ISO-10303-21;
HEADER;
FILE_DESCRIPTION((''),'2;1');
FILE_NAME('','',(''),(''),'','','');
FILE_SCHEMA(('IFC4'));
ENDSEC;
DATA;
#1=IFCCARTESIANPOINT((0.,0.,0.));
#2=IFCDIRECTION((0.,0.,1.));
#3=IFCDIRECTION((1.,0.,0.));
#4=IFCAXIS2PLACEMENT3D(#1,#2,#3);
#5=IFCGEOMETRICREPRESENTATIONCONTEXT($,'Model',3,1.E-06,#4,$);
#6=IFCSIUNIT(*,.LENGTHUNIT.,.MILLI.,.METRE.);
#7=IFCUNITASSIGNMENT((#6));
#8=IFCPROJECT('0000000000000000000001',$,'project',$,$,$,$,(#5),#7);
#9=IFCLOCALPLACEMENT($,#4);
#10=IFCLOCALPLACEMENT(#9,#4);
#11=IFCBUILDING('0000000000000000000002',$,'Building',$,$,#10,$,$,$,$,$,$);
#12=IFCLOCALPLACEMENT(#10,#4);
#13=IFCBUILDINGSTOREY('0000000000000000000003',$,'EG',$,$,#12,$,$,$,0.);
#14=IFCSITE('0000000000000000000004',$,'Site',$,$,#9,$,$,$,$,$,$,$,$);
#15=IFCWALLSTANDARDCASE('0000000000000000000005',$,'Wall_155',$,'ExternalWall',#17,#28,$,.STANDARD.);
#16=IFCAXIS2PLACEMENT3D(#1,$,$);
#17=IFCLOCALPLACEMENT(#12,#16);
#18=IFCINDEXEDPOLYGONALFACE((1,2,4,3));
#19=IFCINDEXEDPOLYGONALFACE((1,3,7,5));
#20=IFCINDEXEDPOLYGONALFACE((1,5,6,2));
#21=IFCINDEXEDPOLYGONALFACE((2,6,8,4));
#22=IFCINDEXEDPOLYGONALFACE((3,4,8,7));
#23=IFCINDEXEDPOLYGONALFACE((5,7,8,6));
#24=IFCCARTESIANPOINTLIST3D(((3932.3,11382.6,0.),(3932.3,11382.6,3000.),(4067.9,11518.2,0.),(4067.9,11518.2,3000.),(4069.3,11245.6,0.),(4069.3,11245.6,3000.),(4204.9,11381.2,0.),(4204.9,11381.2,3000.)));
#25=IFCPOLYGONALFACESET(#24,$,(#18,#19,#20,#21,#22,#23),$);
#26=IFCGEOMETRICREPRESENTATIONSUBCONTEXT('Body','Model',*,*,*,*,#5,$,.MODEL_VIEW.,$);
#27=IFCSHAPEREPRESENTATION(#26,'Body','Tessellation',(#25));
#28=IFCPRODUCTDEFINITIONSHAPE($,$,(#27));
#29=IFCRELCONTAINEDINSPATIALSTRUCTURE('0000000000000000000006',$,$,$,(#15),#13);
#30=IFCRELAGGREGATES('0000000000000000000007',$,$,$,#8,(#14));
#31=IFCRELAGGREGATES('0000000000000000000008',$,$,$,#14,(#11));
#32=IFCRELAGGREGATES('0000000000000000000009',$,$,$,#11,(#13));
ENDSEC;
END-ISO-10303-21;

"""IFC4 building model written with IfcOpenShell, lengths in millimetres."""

from ifc_helpers import new_model, si_unit, frame, origin_with_axes, place, context, subcontext, project, spatial, rectangle, extrude, element, save


model = new_model("IFC4")

# Units and contexts
model_context = context("Model", 3, precision=1e-06, world=origin_with_axes())
body_context = subcontext(model_context, "Body", "Model", "MODEL_VIEW")
ifc_project = project(units=[si_unit("LENGTHUNIT", "METRE", prefix="MILLI")], contexts=[model_context])

# Site, building, storey
site_placement = place(None, origin_with_axes())
site = spatial("IfcSite", under=ifc_project, at=site_placement, Name="Site")
building_placement = place(site_placement, origin_with_axes())
building = spatial("IfcBuilding", under=site, at=building_placement, Name="Building")
storey_placement = place(building_placement, origin_with_axes())
storey = spatial("IfcBuildingStorey", under=building, at=storey_placement, Name="EG", Elevation=0.0)

# Wall
wall_1_placement = place(storey_placement, origin_with_axes())
element("IfcWallStandardCase", 1, at=wall_1_placement, inside=storey, Name="Wall_155", ObjectType="ExternalWall", PredefinedType="STANDARD", context=body_context, shape_type="SweptSolid", body=[
    extrude(rectangle(XDim=193.7, YDim=191.8), frame((4068.6, 11381.9, 0.0), z_axis=(0.0, 0.0, 1.0), x_axis=(-0.707107, 0.707107, 0.0)), (0.0, 0.0, 1.0), 3000.0),
])

save(model, "model.ifc")
